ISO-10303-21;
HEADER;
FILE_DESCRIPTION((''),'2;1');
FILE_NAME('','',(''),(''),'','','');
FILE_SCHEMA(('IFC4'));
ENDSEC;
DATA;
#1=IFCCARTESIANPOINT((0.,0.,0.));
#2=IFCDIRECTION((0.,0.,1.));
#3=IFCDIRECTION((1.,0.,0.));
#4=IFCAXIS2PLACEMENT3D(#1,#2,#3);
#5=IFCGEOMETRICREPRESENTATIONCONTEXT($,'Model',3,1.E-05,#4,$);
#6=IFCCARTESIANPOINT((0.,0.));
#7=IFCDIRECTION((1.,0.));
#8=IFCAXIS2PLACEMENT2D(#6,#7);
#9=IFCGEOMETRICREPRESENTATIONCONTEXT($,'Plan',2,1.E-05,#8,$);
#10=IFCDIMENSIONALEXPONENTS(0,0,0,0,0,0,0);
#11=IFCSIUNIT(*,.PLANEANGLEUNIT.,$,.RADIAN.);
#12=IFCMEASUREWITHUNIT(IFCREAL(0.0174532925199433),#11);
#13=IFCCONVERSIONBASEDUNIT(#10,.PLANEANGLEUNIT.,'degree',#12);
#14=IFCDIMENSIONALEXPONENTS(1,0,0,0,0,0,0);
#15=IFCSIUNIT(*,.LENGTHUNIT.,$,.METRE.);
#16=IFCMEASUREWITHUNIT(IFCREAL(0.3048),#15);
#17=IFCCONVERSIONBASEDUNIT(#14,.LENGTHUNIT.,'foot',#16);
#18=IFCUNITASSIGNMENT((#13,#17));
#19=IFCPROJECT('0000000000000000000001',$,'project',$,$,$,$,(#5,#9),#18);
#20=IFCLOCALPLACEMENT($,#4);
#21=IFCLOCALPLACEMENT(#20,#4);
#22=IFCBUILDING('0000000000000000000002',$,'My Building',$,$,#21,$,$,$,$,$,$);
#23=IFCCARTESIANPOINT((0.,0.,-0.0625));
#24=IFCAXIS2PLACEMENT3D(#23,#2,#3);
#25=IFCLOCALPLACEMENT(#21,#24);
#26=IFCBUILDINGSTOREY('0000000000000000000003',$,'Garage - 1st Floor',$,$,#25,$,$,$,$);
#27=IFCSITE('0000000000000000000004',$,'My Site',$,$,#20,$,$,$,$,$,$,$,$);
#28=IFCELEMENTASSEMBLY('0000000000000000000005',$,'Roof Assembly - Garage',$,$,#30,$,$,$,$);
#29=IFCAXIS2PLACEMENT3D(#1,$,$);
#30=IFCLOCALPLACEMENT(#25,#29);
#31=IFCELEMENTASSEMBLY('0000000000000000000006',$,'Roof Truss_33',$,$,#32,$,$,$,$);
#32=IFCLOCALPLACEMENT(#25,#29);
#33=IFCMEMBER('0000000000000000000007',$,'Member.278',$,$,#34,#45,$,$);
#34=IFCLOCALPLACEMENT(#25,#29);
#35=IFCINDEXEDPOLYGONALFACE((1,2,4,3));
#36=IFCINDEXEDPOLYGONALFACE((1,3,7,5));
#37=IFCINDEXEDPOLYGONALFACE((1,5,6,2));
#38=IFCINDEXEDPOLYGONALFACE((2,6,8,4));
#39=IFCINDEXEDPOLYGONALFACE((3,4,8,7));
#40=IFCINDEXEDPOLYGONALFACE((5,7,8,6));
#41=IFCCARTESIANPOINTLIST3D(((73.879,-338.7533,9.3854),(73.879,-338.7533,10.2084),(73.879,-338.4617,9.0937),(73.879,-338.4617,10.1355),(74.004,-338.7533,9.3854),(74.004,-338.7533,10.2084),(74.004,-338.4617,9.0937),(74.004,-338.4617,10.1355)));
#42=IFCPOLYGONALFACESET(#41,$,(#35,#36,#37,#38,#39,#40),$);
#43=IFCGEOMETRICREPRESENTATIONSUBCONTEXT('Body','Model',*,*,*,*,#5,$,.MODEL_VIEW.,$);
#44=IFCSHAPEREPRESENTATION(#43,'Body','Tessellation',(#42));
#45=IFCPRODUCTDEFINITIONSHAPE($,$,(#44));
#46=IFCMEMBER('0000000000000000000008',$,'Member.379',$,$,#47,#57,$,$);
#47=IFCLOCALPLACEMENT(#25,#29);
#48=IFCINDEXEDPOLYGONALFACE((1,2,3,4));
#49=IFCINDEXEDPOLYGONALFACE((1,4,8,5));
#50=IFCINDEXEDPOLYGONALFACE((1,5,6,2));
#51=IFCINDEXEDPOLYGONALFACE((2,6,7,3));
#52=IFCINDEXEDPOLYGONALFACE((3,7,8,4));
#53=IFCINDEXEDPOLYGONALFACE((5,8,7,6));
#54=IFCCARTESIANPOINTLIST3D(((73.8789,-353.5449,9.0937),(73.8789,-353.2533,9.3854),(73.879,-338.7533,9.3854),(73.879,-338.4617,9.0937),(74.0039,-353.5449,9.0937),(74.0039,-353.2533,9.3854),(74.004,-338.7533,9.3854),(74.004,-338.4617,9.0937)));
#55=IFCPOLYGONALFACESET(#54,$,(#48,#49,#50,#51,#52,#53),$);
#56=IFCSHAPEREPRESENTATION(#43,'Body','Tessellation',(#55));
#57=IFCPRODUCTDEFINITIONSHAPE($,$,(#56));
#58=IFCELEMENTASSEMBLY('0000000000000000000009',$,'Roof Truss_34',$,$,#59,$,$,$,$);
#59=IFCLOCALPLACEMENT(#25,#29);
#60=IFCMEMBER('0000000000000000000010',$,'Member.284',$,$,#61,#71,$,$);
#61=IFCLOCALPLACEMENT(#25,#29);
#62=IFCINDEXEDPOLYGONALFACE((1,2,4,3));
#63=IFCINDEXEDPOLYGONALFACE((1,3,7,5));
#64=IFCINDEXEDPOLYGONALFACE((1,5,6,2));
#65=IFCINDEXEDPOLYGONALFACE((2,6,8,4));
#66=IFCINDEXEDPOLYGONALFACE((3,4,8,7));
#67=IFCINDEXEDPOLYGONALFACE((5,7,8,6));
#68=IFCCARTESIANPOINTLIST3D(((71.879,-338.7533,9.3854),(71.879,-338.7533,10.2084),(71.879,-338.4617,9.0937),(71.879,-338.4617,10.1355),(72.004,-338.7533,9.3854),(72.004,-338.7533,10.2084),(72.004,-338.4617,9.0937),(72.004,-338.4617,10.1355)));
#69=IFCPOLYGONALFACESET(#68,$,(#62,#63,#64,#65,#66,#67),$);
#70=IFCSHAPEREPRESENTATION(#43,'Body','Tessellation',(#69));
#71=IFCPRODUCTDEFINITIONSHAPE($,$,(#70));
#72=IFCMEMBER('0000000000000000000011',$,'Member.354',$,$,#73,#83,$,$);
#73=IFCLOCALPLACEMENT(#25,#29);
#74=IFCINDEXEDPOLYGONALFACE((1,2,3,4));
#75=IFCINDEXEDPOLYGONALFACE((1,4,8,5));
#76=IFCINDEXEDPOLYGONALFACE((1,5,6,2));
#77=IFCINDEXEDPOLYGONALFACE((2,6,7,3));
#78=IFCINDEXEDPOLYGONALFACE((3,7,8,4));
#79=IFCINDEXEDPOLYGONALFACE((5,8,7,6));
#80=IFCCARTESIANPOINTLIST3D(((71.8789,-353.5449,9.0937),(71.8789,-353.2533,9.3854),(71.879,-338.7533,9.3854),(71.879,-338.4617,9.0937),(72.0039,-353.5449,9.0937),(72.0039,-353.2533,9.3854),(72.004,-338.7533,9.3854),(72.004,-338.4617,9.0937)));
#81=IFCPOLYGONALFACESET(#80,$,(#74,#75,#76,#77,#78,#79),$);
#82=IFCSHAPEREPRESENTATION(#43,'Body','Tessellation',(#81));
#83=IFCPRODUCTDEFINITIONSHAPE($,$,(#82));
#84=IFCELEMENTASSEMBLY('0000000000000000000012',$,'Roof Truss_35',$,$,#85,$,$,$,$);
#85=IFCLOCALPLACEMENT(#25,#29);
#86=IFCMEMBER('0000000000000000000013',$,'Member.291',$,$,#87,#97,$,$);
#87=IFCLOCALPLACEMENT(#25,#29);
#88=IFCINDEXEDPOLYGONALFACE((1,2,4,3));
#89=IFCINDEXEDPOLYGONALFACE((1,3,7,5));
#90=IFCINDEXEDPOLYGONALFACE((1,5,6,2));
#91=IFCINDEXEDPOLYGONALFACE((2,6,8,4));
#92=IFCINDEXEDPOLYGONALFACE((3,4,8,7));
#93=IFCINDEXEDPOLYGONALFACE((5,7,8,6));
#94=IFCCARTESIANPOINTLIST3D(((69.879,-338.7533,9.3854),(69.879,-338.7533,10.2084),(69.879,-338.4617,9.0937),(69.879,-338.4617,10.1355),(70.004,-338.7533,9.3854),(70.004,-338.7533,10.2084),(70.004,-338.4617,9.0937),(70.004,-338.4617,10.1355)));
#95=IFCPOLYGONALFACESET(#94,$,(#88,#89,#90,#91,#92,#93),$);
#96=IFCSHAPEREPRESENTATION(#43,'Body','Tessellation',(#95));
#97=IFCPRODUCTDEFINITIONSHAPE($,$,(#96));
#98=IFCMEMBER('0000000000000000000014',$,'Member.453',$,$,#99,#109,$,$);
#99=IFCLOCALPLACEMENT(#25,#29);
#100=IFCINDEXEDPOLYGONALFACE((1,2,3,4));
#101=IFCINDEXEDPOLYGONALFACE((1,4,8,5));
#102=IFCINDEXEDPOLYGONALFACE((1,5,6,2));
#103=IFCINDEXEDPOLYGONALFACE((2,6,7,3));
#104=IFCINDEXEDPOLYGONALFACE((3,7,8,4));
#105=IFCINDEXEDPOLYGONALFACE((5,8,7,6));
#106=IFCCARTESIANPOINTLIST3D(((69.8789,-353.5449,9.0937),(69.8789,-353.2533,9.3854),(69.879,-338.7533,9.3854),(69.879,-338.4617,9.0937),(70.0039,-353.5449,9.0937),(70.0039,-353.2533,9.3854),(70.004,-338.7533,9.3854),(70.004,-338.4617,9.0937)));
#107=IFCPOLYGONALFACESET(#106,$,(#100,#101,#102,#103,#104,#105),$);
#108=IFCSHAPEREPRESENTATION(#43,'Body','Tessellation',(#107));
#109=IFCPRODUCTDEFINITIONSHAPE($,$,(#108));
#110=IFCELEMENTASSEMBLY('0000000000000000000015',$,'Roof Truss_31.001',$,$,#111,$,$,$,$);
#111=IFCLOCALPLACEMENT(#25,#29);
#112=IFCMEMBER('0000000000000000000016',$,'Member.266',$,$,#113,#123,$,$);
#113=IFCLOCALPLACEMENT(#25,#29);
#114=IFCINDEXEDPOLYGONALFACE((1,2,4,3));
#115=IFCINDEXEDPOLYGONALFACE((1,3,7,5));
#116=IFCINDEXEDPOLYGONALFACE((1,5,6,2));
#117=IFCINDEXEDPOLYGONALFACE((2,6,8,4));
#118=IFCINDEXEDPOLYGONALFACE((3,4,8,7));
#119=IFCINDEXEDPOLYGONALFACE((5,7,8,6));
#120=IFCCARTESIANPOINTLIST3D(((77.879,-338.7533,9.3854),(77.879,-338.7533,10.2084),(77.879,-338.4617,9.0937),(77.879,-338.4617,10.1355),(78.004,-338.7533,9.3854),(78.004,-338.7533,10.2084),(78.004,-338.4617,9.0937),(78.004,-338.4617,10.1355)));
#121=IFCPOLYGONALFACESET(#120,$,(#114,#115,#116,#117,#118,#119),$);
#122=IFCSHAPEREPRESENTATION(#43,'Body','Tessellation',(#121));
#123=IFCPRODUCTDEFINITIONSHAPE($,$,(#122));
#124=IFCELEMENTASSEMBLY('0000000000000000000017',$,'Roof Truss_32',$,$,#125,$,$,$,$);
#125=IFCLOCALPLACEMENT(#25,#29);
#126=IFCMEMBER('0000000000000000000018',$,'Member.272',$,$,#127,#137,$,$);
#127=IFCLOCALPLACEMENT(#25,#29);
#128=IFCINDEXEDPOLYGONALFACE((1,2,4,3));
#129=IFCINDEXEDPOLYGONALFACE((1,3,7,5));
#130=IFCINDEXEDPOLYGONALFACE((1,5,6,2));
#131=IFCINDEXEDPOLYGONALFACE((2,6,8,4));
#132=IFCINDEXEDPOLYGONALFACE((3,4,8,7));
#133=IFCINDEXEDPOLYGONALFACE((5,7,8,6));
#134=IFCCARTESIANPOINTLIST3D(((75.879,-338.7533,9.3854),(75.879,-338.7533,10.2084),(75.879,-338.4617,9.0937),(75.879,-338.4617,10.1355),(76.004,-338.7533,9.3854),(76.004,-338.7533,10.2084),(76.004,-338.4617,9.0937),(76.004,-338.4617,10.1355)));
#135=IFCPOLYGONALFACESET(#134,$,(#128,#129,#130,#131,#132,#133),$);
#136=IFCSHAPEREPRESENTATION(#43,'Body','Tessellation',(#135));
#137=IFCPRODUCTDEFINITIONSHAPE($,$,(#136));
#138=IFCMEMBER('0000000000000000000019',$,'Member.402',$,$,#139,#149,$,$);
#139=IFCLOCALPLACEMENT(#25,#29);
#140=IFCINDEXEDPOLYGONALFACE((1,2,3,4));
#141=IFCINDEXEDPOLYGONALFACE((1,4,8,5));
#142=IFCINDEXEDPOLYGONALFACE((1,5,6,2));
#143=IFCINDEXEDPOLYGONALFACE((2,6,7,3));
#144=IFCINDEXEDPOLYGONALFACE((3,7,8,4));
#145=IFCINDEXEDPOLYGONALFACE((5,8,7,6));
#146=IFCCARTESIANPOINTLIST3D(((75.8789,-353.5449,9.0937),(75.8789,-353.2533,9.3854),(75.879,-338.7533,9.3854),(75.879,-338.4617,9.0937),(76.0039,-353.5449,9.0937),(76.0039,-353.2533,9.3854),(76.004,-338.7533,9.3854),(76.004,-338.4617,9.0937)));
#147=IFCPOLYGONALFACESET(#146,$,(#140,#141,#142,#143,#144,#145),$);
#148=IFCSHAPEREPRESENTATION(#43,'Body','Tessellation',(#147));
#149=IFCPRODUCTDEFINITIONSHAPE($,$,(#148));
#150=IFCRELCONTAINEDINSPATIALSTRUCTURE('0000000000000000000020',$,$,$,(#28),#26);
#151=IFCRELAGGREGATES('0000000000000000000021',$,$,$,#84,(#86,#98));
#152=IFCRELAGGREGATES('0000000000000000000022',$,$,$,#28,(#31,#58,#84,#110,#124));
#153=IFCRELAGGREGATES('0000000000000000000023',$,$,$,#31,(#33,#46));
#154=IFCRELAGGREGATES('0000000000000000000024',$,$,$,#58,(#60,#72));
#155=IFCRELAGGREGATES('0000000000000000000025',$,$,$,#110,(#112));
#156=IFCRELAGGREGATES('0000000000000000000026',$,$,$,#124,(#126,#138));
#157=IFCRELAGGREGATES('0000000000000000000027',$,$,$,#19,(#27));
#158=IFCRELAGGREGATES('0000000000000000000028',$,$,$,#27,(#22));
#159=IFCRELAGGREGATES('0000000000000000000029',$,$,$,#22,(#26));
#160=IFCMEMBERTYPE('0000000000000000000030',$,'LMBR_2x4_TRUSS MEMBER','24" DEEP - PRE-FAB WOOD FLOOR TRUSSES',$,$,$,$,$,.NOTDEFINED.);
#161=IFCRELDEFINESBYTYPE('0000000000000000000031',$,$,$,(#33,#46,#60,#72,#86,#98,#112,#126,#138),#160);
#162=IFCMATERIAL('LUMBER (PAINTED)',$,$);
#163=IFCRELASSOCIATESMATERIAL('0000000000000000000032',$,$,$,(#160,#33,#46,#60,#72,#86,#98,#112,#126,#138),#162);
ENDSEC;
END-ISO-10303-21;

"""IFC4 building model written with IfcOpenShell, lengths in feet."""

from ifc_helpers import new_model, entity, si_unit, converted_unit, frame, origin_with_axes, origin_2d_with_axis, place, context, subcontext, project, spatial, indexed_curve, outline, extrude, clip, halfspace, material, material_profile, profile_set, profile_usage, type_object, element, aggregate, save


model = new_model("IFC4")

# Units and contexts
model_context = context("Model", 3, precision=1e-05, world=origin_with_axes())
plan_context = context("Plan", 2, precision=1e-05, world=origin_2d_with_axis())
body_context = subcontext(model_context, "Body", "Model", "MODEL_VIEW")
ifc_project = project(units=[converted_unit("PLANEANGLEUNIT", "degree", entity("IfcReal", 0.0174532925199433), si_unit("PLANEANGLEUNIT", "RADIAN"), dimensions=[0, 0, 0, 0, 0, 0, 0]), converted_unit("LENGTHUNIT", "foot", entity("IfcReal", 0.3048), si_unit("LENGTHUNIT", "METRE"), dimensions=[1, 0, 0, 0, 0, 0, 0])], contexts=[model_context, plan_context])

# Site, building, storey
site_placement = place(None, origin_with_axes())
site = spatial("IfcSite", under=ifc_project, at=site_placement, Name="My Site")
building_placement = place(site_placement, origin_with_axes())
building = spatial("IfcBuilding", under=site, at=building_placement, Name="My Building")
storey_placement = place(building_placement, frame((0.0, 0.0, -0.0625), z_axis=(0.0, 0.0, 1.0), x_axis=(1.0, 0.0, 0.0)))
storey = spatial("IfcBuildingStorey", under=building, at=storey_placement, Name="Garage - 1st Floor")

# Element assemblies, members
assembly_1_placement = place(storey_placement, frame((0.0, 0.0, 0.125), z_axis=(0.0, 0.0, 1.0), x_axis=(1.0, 0.0, 0.0)))
assembly_1 = element("IfcElementAssembly", 1, at=assembly_1_placement, inside=storey, Name="Roof Assembly - Garage")
assembly_2_placement = place(assembly_1_placement, frame((73.9415, -346.0033, 12.5192), z_axis=(0.0, 0.0, 1.0), x_axis=(0.0, 1.0, 0.0)))
assembly_2 = element("IfcElementAssembly", 2, at=assembly_2_placement, Name="Roof Truss_33")
ifc_material = material(Name="LUMBER (PAINTED)")
ifc_material_profile_1 = material_profile(ifc_material, outline(indexed_curve([(-0.0625, -0.1458), (0.0625, -0.1458), (0.0625, 0.1458), (-0.0625, 0.1458), (-0.0625, -0.1458)])))
ifc_profile_set_1 = profile_set([ifc_material_profile_1])
member_type_1 = type_object("IfcMemberType", Name="LMBR_2x4_TRUSS MEMBER", Description="24\" DEEP - PRE-FAB WOOD FLOOR TRUSSES", PredefinedType="NOTDEFINED", material=ifc_profile_set_1)
ifc_profile_usage_1 = profile_usage(ifc_profile_set_1)
member_1_placement = place(assembly_2_placement, frame((7.3958, 0.0, -2.1806), z_axis=(0.0, 0.0, -1.0), x_axis=(0.0, -1.0, 0.0)))
member_1 = element("IfcMember", 3, at=member_1_placement, type_object=member_type_1, material=ifc_profile_usage_1, Name="Member.278", context=body_context, shape_type="Clipping", body=[
    clip(clip(extrude(outline(indexed_curve([(-0.0625, -0.1458), (0.0625, -0.1458), (0.0625, 0.1458), (-0.0625, 0.1458), (-0.0625, -0.1458)])), origin_with_axes(), (0.0, 0.0, 1.0), 1.3698), halfspace(frame((0.0, 7.5424, -1.5944), z_axis=(0.0, -0.242599, -0.970127), x_axis=(-1.0, 0.0, 0.0)), False)), halfspace(frame((-397.5032, -0.1458, 1.3698), z_axis=(0.0, 0.707099, 0.707114), x_axis=(1.0, 0.0, 0.0)), False)),
])
ifc_profile_usage_2 = profile_usage(ifc_profile_set_1)
member_2_placement = place(assembly_2_placement, frame((7.5416, 0.0, -3.4046), z_axis=(-1.0, 0.0, 0.0), x_axis=(0.0, 1.0, 0.0)))
member_2 = element("IfcMember", 4, at=member_2_placement, type_object=member_type_1, material=ifc_profile_usage_2, Name="Member.379", context=body_context, shape_type="Clipping", body=[
    clip(clip(extrude(outline(indexed_curve([(-0.0625, -0.1458), (0.0625, -0.1458), (0.0625, 0.1458), (-0.0625, 0.1458), (-0.0625, -0.1458)])), origin_with_axes(), (0.0, 0.0, 1.0), 15.0833), halfspace(frame((397.5032, 0.1458, 0.0001), z_axis=(0.0, -0.707114, -0.707099), x_axis=(-1.0, 0.0, 0.0)), False)), halfspace(frame((397.5032, 0.1458, 15.0832), z_axis=(0.0, -0.707107, 0.707107), x_axis=(-1.0, 0.0, 0.0)), False)),
])
assembly_3_placement = place(assembly_1_placement, frame((71.9415, -346.0033, 12.5192), z_axis=(0.0, 0.0, 1.0), x_axis=(0.0, 1.0, 0.0)))
assembly_3 = element("IfcElementAssembly", 5, at=assembly_3_placement, Name="Roof Truss_34")
ifc_profile_usage_3 = profile_usage(ifc_profile_set_1)
member_3_placement = place(assembly_3_placement, frame((7.3958, 0.0, -2.1806), z_axis=(0.0, 0.0, -1.0), x_axis=(0.0, -1.0, 0.0)))
member_3 = element("IfcMember", 6, at=member_3_placement, type_object=member_type_1, material=ifc_profile_usage_3, Name="Member.284", context=body_context, shape_type="Clipping", body=[
    clip(clip(extrude(outline(indexed_curve([(-0.0625, -0.1458), (0.0625, -0.1458), (0.0625, 0.1458), (-0.0625, 0.1458), (-0.0625, -0.1458)])), origin_with_axes(), (0.0, 0.0, 1.0), 1.3698), halfspace(frame((0.0, 7.5424, -1.5944), z_axis=(0.0, -0.242599, -0.970127), x_axis=(-1.0, 0.0, 0.0)), False)), halfspace(frame((-397.5032, -0.1458, 1.3698), z_axis=(0.0, 0.707099, 0.707114), x_axis=(1.0, 0.0, 0.0)), False)),
])
ifc_profile_usage_4 = profile_usage(ifc_profile_set_1)
member_4_placement = place(assembly_3_placement, frame((7.5416, 0.0, -3.4046), z_axis=(-1.0, 0.0, 0.0), x_axis=(0.0, 1.0, 0.0)))
member_4 = element("IfcMember", 7, at=member_4_placement, type_object=member_type_1, material=ifc_profile_usage_4, Name="Member.354", context=body_context, shape_type="Clipping", body=[
    clip(clip(extrude(outline(indexed_curve([(-0.0625, -0.1458), (0.0625, -0.1458), (0.0625, 0.1458), (-0.0625, 0.1458), (-0.0625, -0.1458)])), origin_with_axes(), (0.0, 0.0, 1.0), 15.0833), halfspace(frame((397.5032, 0.1458, 0.0001), z_axis=(0.0, -0.707114, -0.707099), x_axis=(-1.0, 0.0, 0.0)), False)), halfspace(frame((397.5032, 0.1458, 15.0832), z_axis=(0.0, -0.707107, 0.707107), x_axis=(-1.0, 0.0, 0.0)), False)),
])
assembly_4_placement = place(assembly_1_placement, frame((69.9415, -346.0033, 12.5192), z_axis=(0.0, 0.0, 1.0), x_axis=(0.0, 1.0, 0.0)))
assembly_4 = element("IfcElementAssembly", 8, at=assembly_4_placement, Name="Roof Truss_35")
ifc_profile_usage_5 = profile_usage(ifc_profile_set_1)
member_5_placement = place(assembly_4_placement, frame((7.3958, 0.0, -2.1806), z_axis=(0.0, 0.0, -1.0), x_axis=(0.0, -1.0, 0.0)))
member_5 = element("IfcMember", 9, at=member_5_placement, type_object=member_type_1, material=ifc_profile_usage_5, Name="Member.291", context=body_context, shape_type="Clipping", body=[
    clip(clip(extrude(outline(indexed_curve([(-0.0625, -0.1458), (0.0625, -0.1458), (0.0625, 0.1458), (-0.0625, 0.1458), (-0.0625, -0.1458)])), origin_with_axes(), (0.0, 0.0, 1.0), 1.3698), halfspace(frame((0.0, 7.5424, -1.5944), z_axis=(0.0, -0.242599, -0.970127), x_axis=(-1.0, 0.0, 0.0)), False)), halfspace(frame((-397.5032, -0.1458, 1.3698), z_axis=(0.0, 0.707099, 0.707114), x_axis=(1.0, 0.0, 0.0)), False)),
])
ifc_profile_usage_6 = profile_usage(ifc_profile_set_1)
member_6_placement = place(assembly_4_placement, frame((7.5416, 0.0, -3.4046), z_axis=(-1.0, 0.0, 0.0), x_axis=(0.0, 1.0, 0.0)))
member_6 = element("IfcMember", 10, at=member_6_placement, type_object=member_type_1, material=ifc_profile_usage_6, Name="Member.453", context=body_context, shape_type="Clipping", body=[
    clip(clip(extrude(outline(indexed_curve([(-0.0625, -0.1458), (0.0625, -0.1458), (0.0625, 0.1458), (-0.0625, 0.1458), (-0.0625, -0.1458)])), origin_with_axes(), (0.0, 0.0, 1.0), 15.0833), halfspace(frame((397.5032, 0.1458, 0.0001), z_axis=(0.0, -0.707114, -0.707099), x_axis=(-1.0, 0.0, 0.0)), False)), halfspace(frame((397.5032, 0.1458, 15.0832), z_axis=(0.0, -0.707107, 0.707107), x_axis=(-1.0, 0.0, 0.0)), False)),
])
aggregate(assembly_4, [member_5, member_6])
assembly_5_placement = place(assembly_1_placement, frame((77.9415, -346.0033, 12.5192), z_axis=(0.0, 0.0, 1.0), x_axis=(0.0, 1.0, 0.0)))
assembly_5 = element("IfcElementAssembly", 11, at=assembly_5_placement, Name="Roof Truss_31.001")
ifc_profile_usage_7 = profile_usage(ifc_profile_set_1)
member_7_placement = place(assembly_5_placement, frame((7.3958, 0.0, -2.1806), z_axis=(0.0, 0.0, -1.0), x_axis=(0.0, -1.0, 0.0)))
member_7 = element("IfcMember", 12, at=member_7_placement, type_object=member_type_1, material=ifc_profile_usage_7, Name="Member.266", context=body_context, shape_type="Clipping", body=[
    clip(clip(extrude(outline(indexed_curve([(-0.0625, -0.1458), (0.0625, -0.1458), (0.0625, 0.1458), (-0.0625, 0.1458), (-0.0625, -0.1458)])), origin_with_axes(), (0.0, 0.0, 1.0), 1.3698), halfspace(frame((0.0, 7.5424, -1.5944), z_axis=(0.0, -0.242599, -0.970127), x_axis=(-1.0, 0.0, 0.0)), False)), halfspace(frame((-397.5032, -0.1458, 1.3698), z_axis=(0.0, 0.707099, 0.707114), x_axis=(1.0, 0.0, 0.0)), False)),
])
assembly_6_placement = place(assembly_1_placement, frame((75.9415, -346.0033, 12.5192), z_axis=(0.0, 0.0, 1.0), x_axis=(0.0, 1.0, 0.0)))
assembly_6 = element("IfcElementAssembly", 13, at=assembly_6_placement, Name="Roof Truss_32")
aggregate(assembly_1, [assembly_2, assembly_3, assembly_4, assembly_5, assembly_6])
ifc_profile_usage_8 = profile_usage(ifc_profile_set_1)
member_8_placement = place(assembly_6_placement, frame((7.3958, 0.0, -2.1806), z_axis=(0.0, 0.0, -1.0), x_axis=(0.0, -1.0, 0.0)))
member_8 = element("IfcMember", 14, at=member_8_placement, type_object=member_type_1, material=ifc_profile_usage_8, Name="Member.272", context=body_context, shape_type="Clipping", body=[
    clip(clip(extrude(outline(indexed_curve([(-0.0625, -0.1458), (0.0625, -0.1458), (0.0625, 0.1458), (-0.0625, 0.1458), (-0.0625, -0.1458)])), origin_with_axes(), (0.0, 0.0, 1.0), 1.3698), halfspace(frame((0.0, 7.5424, -1.5944), z_axis=(0.0, -0.242599, -0.970127), x_axis=(-1.0, 0.0, 0.0)), False)), halfspace(frame((-397.5032, -0.1458, 1.3698), z_axis=(0.0, 0.707099, 0.707114), x_axis=(1.0, 0.0, 0.0)), False)),
])
ifc_profile_usage_9 = profile_usage(ifc_profile_set_1)
member_9_placement = place(assembly_6_placement, frame((7.5416, 0.0, -3.4046), z_axis=(-1.0, 0.0, 0.0), x_axis=(0.0, 1.0, 0.0)))
member_9 = element("IfcMember", 15, at=member_9_placement, type_object=member_type_1, material=ifc_profile_usage_9, Name="Member.402", context=body_context, shape_type="Clipping", body=[
    clip(clip(extrude(outline(indexed_curve([(-0.0625, -0.1458), (0.0625, -0.1458), (0.0625, 0.1458), (-0.0625, 0.1458), (-0.0625, -0.1458)])), origin_with_axes(), (0.0, 0.0, 1.0), 15.0833), halfspace(frame((397.5032, 0.1458, 0.0001), z_axis=(0.0, -0.707114, -0.707099), x_axis=(-1.0, 0.0, 0.0)), False)), halfspace(frame((397.5032, 0.1458, 15.0832), z_axis=(0.0, -0.707107, 0.707107), x_axis=(-1.0, 0.0, 0.0)), False)),
])
aggregate(assembly_2, [member_1, member_2])
aggregate(assembly_3, [member_3, member_4])
aggregate(assembly_5, [member_7])
aggregate(assembly_6, [member_8, member_9])

save(model, "model.ifc")
